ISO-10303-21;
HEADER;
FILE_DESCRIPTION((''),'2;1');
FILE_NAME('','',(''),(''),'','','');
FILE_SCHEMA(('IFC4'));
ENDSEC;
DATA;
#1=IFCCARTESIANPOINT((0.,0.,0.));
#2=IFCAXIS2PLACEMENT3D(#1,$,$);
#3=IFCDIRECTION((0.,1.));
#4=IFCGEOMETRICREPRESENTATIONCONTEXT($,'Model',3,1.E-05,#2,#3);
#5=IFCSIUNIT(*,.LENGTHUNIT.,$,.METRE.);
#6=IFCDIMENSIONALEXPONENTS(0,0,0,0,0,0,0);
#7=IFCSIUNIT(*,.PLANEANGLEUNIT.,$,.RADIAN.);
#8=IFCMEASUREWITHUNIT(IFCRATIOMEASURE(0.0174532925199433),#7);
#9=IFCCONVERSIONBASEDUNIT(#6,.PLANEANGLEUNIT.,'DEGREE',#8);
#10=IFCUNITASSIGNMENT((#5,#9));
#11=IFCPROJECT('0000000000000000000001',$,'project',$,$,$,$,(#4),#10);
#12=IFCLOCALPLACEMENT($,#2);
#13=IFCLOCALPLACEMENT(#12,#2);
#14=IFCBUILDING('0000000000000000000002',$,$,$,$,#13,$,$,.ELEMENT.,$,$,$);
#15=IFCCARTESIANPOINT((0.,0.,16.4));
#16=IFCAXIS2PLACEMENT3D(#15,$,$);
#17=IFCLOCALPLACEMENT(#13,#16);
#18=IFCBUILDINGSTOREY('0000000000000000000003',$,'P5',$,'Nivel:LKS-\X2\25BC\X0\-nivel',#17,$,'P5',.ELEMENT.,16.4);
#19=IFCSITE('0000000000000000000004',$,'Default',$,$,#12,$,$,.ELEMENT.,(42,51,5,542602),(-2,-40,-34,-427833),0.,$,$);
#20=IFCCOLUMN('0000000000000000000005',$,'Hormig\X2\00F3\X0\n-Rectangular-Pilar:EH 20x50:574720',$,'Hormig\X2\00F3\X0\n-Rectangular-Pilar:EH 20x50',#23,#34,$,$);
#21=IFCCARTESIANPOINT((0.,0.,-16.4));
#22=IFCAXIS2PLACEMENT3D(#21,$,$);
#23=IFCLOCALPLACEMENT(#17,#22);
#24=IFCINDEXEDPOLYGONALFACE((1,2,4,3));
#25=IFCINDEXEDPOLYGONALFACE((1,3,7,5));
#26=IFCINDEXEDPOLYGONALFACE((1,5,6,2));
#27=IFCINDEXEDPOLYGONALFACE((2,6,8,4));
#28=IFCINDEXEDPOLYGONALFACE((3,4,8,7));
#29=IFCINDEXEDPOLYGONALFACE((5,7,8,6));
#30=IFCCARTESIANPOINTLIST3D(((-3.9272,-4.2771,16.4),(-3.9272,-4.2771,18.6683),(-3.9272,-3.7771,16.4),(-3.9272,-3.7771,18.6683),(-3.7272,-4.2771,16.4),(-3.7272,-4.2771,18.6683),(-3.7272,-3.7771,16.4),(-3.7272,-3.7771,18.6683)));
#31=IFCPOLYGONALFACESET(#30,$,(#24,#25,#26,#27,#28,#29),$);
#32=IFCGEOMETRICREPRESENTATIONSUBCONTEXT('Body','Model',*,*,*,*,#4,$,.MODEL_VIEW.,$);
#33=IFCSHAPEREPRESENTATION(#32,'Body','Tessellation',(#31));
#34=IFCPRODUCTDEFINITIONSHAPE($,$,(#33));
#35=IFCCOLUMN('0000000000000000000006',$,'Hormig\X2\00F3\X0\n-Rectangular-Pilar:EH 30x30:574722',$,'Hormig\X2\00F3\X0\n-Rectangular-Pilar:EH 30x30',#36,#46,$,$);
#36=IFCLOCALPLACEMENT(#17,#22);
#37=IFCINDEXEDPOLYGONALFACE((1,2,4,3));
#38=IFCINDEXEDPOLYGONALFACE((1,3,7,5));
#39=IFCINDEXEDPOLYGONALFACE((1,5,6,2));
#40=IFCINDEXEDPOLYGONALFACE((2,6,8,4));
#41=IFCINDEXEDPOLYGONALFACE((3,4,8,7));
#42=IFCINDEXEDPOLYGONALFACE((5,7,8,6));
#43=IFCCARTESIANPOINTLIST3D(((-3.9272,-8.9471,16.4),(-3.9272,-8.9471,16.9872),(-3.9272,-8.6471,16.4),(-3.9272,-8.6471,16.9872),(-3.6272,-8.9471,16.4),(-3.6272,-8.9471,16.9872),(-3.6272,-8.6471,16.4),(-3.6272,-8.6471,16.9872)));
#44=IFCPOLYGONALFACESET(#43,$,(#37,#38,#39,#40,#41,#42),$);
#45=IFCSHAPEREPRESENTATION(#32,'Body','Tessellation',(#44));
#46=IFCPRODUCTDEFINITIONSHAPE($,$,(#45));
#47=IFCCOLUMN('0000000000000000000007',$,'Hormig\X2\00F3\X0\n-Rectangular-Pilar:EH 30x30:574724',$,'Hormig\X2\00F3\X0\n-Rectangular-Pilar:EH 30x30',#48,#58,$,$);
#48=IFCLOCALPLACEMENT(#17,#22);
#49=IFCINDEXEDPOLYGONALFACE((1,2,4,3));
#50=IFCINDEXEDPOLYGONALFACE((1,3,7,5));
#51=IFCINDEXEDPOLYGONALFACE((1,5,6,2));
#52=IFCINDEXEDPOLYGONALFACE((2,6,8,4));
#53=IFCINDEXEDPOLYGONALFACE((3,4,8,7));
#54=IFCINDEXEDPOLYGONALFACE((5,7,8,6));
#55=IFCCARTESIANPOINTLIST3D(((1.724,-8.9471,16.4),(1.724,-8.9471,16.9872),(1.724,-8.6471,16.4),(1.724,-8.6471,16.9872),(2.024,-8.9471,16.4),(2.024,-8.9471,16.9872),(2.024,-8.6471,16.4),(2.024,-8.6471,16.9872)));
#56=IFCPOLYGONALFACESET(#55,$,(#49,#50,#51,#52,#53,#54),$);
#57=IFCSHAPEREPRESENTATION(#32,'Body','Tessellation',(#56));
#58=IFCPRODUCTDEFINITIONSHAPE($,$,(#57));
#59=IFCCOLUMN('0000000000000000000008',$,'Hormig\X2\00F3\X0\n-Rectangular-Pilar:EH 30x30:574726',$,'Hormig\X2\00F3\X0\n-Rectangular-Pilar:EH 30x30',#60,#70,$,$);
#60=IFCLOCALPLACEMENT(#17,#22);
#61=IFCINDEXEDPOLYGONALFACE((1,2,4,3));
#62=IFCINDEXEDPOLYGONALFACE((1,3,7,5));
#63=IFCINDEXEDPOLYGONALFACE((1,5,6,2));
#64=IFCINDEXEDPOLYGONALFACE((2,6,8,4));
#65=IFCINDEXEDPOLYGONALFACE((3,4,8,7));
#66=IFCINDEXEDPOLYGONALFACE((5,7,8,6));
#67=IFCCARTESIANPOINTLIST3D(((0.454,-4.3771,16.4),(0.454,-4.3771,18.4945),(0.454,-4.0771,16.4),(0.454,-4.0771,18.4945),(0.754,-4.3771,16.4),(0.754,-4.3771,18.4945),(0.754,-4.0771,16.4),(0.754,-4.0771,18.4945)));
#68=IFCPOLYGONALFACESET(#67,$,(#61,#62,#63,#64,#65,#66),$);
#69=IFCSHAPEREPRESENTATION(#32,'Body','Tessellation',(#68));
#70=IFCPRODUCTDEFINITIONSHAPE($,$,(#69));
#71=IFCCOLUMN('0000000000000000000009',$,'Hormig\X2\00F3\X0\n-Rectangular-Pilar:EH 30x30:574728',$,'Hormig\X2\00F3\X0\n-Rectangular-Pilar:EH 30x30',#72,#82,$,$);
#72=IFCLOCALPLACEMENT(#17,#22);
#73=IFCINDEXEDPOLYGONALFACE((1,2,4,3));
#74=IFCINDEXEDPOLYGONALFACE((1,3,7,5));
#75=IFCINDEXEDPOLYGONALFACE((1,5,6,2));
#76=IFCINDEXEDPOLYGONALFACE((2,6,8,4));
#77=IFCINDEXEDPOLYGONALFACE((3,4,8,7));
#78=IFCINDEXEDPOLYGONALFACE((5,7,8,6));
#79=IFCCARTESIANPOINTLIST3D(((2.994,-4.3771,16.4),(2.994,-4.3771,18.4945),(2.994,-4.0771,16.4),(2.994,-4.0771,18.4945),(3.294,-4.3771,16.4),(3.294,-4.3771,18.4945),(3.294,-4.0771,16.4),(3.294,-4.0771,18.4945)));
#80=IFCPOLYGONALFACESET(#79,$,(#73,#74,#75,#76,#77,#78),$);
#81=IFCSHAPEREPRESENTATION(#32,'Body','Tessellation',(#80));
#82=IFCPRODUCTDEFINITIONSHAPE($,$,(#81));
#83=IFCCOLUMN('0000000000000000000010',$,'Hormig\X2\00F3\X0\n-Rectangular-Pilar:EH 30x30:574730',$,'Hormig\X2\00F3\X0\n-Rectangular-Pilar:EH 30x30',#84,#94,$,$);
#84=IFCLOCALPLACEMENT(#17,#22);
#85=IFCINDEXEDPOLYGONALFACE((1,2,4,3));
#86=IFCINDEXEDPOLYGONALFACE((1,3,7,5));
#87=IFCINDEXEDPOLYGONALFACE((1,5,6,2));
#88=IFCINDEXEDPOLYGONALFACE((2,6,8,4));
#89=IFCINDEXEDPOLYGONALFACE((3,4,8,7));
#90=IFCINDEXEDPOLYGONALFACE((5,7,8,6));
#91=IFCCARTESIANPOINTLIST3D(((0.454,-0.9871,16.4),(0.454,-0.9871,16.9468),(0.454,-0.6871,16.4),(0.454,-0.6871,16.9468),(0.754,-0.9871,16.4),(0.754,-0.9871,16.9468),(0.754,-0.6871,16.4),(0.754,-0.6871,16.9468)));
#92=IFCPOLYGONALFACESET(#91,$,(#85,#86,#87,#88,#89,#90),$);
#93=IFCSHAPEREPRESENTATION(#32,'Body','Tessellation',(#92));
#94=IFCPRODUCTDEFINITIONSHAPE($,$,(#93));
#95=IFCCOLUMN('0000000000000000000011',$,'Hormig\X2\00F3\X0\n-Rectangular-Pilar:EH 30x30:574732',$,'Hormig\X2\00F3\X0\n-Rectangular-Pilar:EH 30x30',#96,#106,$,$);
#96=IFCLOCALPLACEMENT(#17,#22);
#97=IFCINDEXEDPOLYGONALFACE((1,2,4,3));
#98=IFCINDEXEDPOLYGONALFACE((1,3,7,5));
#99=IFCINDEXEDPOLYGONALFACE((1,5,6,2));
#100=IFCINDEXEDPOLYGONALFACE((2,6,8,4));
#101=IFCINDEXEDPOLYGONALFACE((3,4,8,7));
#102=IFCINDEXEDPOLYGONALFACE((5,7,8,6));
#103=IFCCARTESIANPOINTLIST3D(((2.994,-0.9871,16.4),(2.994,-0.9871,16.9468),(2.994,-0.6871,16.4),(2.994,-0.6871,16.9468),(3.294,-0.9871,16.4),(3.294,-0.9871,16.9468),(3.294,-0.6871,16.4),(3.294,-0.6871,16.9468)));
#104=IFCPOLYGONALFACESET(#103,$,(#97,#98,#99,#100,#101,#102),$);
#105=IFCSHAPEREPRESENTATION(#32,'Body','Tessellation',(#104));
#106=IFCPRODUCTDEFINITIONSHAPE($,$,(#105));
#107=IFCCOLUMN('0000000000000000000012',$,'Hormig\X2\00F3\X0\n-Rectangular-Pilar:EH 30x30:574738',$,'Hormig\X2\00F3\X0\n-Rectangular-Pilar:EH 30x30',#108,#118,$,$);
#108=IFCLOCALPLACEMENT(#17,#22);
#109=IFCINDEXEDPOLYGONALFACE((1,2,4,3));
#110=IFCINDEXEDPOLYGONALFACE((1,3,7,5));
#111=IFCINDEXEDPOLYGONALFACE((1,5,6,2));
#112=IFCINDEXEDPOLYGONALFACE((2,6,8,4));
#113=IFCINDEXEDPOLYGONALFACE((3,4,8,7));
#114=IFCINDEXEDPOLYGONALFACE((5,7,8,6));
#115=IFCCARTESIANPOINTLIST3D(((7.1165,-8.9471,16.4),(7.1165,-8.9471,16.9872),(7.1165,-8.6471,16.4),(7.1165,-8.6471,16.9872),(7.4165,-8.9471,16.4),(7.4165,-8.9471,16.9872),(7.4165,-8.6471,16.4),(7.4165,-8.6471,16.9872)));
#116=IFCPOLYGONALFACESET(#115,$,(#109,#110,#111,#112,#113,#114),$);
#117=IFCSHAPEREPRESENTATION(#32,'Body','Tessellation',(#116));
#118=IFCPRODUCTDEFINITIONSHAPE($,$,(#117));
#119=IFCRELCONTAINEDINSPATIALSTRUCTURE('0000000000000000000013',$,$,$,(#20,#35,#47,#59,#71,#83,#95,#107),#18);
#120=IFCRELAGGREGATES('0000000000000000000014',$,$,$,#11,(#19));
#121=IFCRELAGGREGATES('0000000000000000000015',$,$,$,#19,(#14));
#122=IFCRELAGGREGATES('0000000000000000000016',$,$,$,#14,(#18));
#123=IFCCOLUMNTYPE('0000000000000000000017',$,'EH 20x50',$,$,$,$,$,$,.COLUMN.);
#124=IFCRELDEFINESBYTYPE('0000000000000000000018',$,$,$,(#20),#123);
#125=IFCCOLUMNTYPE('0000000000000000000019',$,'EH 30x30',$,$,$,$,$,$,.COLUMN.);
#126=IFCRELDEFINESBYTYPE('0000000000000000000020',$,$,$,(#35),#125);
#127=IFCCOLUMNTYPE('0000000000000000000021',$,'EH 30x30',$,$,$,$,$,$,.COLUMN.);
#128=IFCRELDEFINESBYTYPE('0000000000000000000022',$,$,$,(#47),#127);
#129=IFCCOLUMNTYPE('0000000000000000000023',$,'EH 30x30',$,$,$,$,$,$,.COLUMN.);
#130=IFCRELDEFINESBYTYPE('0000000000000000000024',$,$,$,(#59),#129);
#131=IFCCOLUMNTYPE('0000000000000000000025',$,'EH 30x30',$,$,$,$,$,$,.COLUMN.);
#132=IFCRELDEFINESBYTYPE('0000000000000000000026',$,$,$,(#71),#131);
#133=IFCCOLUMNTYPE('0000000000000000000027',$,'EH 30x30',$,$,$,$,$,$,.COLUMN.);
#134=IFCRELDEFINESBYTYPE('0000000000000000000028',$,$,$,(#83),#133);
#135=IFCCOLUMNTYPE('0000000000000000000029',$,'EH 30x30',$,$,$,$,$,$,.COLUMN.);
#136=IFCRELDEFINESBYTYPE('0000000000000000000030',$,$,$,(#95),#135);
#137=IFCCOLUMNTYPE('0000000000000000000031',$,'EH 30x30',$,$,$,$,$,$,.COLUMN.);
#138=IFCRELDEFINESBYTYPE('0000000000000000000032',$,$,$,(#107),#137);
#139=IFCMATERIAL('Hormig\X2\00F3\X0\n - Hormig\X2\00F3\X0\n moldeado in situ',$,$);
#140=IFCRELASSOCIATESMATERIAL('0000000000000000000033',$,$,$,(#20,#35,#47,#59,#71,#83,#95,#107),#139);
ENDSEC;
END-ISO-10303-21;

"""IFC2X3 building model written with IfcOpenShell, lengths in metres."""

from ifc_helpers import new_model, entity, si_unit, converted_unit, direction, frame, frame_2d, origin, origin_2d_with_axis, place, context, subcontext, project, spatial, rectangle, extrude, source, transform, mapped, material, type_object, type_shapes, element, save


model = new_model("IFC2X3")

# Units and contexts
model_context = context("Model", 3, precision=1e-05, world=origin(), true_north=direction((0.0, 1.0)))
body_context = subcontext(model_context, "Body", "Model", "MODEL_VIEW")
ifc_project = project(units=[si_unit("LENGTHUNIT", "METRE"), converted_unit("PLANEANGLEUNIT", "DEGREE", entity("IfcRatioMeasure", 0.0174532925199433), si_unit("PLANEANGLEUNIT", "RADIAN"), dimensions=[0, 0, 0, 0, 0, 0, 0])], contexts=[model_context])

# Site, building, storey
site_placement = place(None, origin())
site = spatial("IfcSite", under=ifc_project, at=site_placement, Name="Default", CompositionType="ELEMENT", RefLatitude=(42, 51, 5, 542602), RefLongitude=(-2, -40, -34, -427833), RefElevation=0.0)
building_placement = place(site_placement, origin())
building = spatial("IfcBuilding", under=site, at=building_placement, CompositionType="ELEMENT")
storey_placement = place(building_placement, frame((0.0, 0.0, 16.4)))
storey = spatial("IfcBuildingStorey", under=building, at=storey_placement, Name="P5", ObjectType="Nivel:LKS-▼-nivel", LongName="P5", CompositionType="ELEMENT", Elevation=16.4)

# Columns
ifc_material_1 = material(Name="Hormigón - Hormigón moldeado in situ")
column_type_1 = type_object("IfcColumnType", Name="EH 20x50", PredefinedType="COLUMN")
shared_shape_1 = source(origin(), body_context, "Body", "SweptSolid", [
    extrude(rectangle(XDim=0.5, YDim=0.2, at=origin_2d_with_axis()), frame((-3.8272, -4.0271, 16.4), z_axis=(0.0, 0.0, 1.0), x_axis=(0.0, -1.0, 0.0)), (0.0, 0.0, 1.0), 2.2683),
])
type_shapes(column_type_1, [shared_shape_1])
column_1_placement = place(storey_placement, frame((0.0, 0.0, -16.4)))
element("IfcColumn", 1, at=column_1_placement, inside=storey, type_object=column_type_1, material=ifc_material_1, Name="Hormigón-Rectangular-Pilar:EH 20x50:574720", ObjectType="Hormigón-Rectangular-Pilar:EH 20x50", context=body_context, shape_type="MappedRepresentation", body=[
    mapped(shared_shape_1, transform((0.0, 0.0, 0.0), scale=1.0)),
])
column_type_2 = type_object("IfcColumnType", Name="EH 30x30", PredefinedType="COLUMN")
shared_shape_2 = source(origin(), body_context, "Body", "SweptSolid", [
    extrude(rectangle(XDim=0.3, YDim=0.3, at=origin_2d_with_axis()), frame((-3.7772, -8.7971, 16.4), z_axis=(0.0, 0.0, 1.0), x_axis=(0.0, -1.0, 0.0)), (0.0, 0.0, 1.0), 0.5872),
])
type_shapes(column_type_2, [shared_shape_2])
column_2_placement = place(storey_placement, frame((0.0, 0.0, -16.4)))
element("IfcColumn", 2, at=column_2_placement, inside=storey, type_object=column_type_2, material=ifc_material_1, Name="Hormigón-Rectangular-Pilar:EH 30x30:574722", ObjectType="Hormigón-Rectangular-Pilar:EH 30x30", context=body_context, shape_type="MappedRepresentation", body=[
    mapped(shared_shape_2, transform((0.0, 0.0, 0.0), scale=1.0)),
])
column_type_3 = type_object("IfcColumnType", Name="EH 30x30", PredefinedType="COLUMN")
shared_shape_3 = source(origin(), body_context, "Body", "SweptSolid", [
    extrude(rectangle(XDim=0.3, YDim=0.3, at=frame_2d((0.0, 0.0), x_axis=(1.0, 0.0))), frame((1.874, -8.7971, 16.4), z_axis=(0.0, 0.0, 1.0), x_axis=(0.0, -1.0, 0.0)), (0.0, 0.0, 1.0), 0.5872),
])
type_shapes(column_type_3, [shared_shape_3])
column_3_placement = place(storey_placement, frame((0.0, 0.0, -16.4)))
element("IfcColumn", 3, at=column_3_placement, inside=storey, type_object=column_type_3, material=ifc_material_1, Name="Hormigón-Rectangular-Pilar:EH 30x30:574724", ObjectType="Hormigón-Rectangular-Pilar:EH 30x30", context=body_context, shape_type="MappedRepresentation", body=[
    mapped(shared_shape_3, transform((0.0, 0.0, 0.0), scale=1.0)),
])
column_type_4 = type_object("IfcColumnType", Name="EH 30x30", PredefinedType="COLUMN")
shared_shape_4 = source(origin(), body_context, "Body", "SweptSolid", [
    extrude(rectangle(XDim=0.3, YDim=0.3, at=origin_2d_with_axis()), frame((0.604, -4.2271, 16.4), z_axis=(0.0, 0.0, 1.0), x_axis=(0.0, -1.0, 0.0)), (0.0, 0.0, 1.0), 2.0945),
])
type_shapes(column_type_4, [shared_shape_4])
column_4_placement = place(storey_placement, frame((0.0, 0.0, -16.4)))
element("IfcColumn", 4, at=column_4_placement, inside=storey, type_object=column_type_4, material=ifc_material_1, Name="Hormigón-Rectangular-Pilar:EH 30x30:574726", ObjectType="Hormigón-Rectangular-Pilar:EH 30x30", context=body_context, shape_type="MappedRepresentation", body=[
    mapped(shared_shape_4, transform((0.0, 0.0, 0.0), scale=1.0)),
])
column_type_5 = type_object("IfcColumnType", Name="EH 30x30", PredefinedType="COLUMN")
shared_shape_5 = source(origin(), body_context, "Body", "SweptSolid", [
    extrude(rectangle(XDim=0.3, YDim=0.3, at=origin_2d_with_axis()), frame((3.144, -4.2271, 16.4), z_axis=(0.0, 0.0, 1.0), x_axis=(0.0, -1.0, 0.0)), (0.0, 0.0, 1.0), 2.0945),
])
type_shapes(column_type_5, [shared_shape_5])
column_5_placement = place(storey_placement, frame((0.0, 0.0, -16.4)))
element("IfcColumn", 5, at=column_5_placement, inside=storey, type_object=column_type_5, material=ifc_material_1, Name="Hormigón-Rectangular-Pilar:EH 30x30:574728", ObjectType="Hormigón-Rectangular-Pilar:EH 30x30", context=body_context, shape_type="MappedRepresentation", body=[
    mapped(shared_shape_5, transform((0.0, 0.0, 0.0), scale=1.0)),
])
column_type_6 = type_object("IfcColumnType", Name="EH 30x30", PredefinedType="COLUMN")
shared_shape_6 = source(origin(), body_context, "Body", "SweptSolid", [
    extrude(rectangle(XDim=0.3, YDim=0.3, at=frame_2d((0.0, 0.0), x_axis=(1.0, 0.0))), frame((0.604, -0.8371, 16.4), z_axis=(0.0, 0.0, 1.0), x_axis=(0.0, -1.0, 0.0)), (0.0, 0.0, 1.0), 0.5468),
])
type_shapes(column_type_6, [shared_shape_6])
column_6_placement = place(storey_placement, frame((0.0, 0.0, -16.4)))
element("IfcColumn", 6, at=column_6_placement, inside=storey, type_object=column_type_6, material=ifc_material_1, Name="Hormigón-Rectangular-Pilar:EH 30x30:574730", ObjectType="Hormigón-Rectangular-Pilar:EH 30x30", context=body_context, shape_type="MappedRepresentation", body=[
    mapped(shared_shape_6, transform((0.0, 0.0, 0.0), scale=1.0)),
])
column_type_7 = type_object("IfcColumnType", Name="EH 30x30", PredefinedType="COLUMN")
shared_shape_7 = source(origin(), body_context, "Body", "SweptSolid", [
    extrude(rectangle(XDim=0.3, YDim=0.3, at=frame_2d((0.0, 0.0), x_axis=(1.0, 0.0))), frame((3.144, -0.8371, 16.4), z_axis=(0.0, 0.0, 1.0), x_axis=(0.0, -1.0, 0.0)), (0.0, 0.0, 1.0), 0.5468),
])
type_shapes(column_type_7, [shared_shape_7])
column_7_placement = place(storey_placement, frame((0.0, 0.0, -16.4)))
element("IfcColumn", 7, at=column_7_placement, inside=storey, type_object=column_type_7, material=ifc_material_1, Name="Hormigón-Rectangular-Pilar:EH 30x30:574732", ObjectType="Hormigón-Rectangular-Pilar:EH 30x30", context=body_context, shape_type="MappedRepresentation", body=[
    mapped(shared_shape_7, transform((0.0, 0.0, 0.0), scale=1.0)),
])
column_type_8 = type_object("IfcColumnType", Name="EH 30x30", PredefinedType="COLUMN")
shared_shape_8 = source(origin(), body_context, "Body", "SweptSolid", [
    extrude(rectangle(XDim=0.3, YDim=0.3, at=frame_2d((0.0, 0.0), x_axis=(1.0, 0.0))), frame((7.2665, -8.7971, 16.4), z_axis=(0.0, 0.0, 1.0), x_axis=(0.0, -1.0, 0.0)), (0.0, 0.0, 1.0), 0.5872),
])
type_shapes(column_type_8, [shared_shape_8])
column_8_placement = place(storey_placement, frame((0.0, 0.0, -16.4)))
element("IfcColumn", 8, at=column_8_placement, inside=storey, type_object=column_type_8, material=ifc_material_1, Name="Hormigón-Rectangular-Pilar:EH 30x30:574738", ObjectType="Hormigón-Rectangular-Pilar:EH 30x30", context=body_context, shape_type="MappedRepresentation", body=[
    mapped(shared_shape_8, transform((0.0, 0.0, 0.0), scale=1.0)),
])

save(model, "model.ifc")
